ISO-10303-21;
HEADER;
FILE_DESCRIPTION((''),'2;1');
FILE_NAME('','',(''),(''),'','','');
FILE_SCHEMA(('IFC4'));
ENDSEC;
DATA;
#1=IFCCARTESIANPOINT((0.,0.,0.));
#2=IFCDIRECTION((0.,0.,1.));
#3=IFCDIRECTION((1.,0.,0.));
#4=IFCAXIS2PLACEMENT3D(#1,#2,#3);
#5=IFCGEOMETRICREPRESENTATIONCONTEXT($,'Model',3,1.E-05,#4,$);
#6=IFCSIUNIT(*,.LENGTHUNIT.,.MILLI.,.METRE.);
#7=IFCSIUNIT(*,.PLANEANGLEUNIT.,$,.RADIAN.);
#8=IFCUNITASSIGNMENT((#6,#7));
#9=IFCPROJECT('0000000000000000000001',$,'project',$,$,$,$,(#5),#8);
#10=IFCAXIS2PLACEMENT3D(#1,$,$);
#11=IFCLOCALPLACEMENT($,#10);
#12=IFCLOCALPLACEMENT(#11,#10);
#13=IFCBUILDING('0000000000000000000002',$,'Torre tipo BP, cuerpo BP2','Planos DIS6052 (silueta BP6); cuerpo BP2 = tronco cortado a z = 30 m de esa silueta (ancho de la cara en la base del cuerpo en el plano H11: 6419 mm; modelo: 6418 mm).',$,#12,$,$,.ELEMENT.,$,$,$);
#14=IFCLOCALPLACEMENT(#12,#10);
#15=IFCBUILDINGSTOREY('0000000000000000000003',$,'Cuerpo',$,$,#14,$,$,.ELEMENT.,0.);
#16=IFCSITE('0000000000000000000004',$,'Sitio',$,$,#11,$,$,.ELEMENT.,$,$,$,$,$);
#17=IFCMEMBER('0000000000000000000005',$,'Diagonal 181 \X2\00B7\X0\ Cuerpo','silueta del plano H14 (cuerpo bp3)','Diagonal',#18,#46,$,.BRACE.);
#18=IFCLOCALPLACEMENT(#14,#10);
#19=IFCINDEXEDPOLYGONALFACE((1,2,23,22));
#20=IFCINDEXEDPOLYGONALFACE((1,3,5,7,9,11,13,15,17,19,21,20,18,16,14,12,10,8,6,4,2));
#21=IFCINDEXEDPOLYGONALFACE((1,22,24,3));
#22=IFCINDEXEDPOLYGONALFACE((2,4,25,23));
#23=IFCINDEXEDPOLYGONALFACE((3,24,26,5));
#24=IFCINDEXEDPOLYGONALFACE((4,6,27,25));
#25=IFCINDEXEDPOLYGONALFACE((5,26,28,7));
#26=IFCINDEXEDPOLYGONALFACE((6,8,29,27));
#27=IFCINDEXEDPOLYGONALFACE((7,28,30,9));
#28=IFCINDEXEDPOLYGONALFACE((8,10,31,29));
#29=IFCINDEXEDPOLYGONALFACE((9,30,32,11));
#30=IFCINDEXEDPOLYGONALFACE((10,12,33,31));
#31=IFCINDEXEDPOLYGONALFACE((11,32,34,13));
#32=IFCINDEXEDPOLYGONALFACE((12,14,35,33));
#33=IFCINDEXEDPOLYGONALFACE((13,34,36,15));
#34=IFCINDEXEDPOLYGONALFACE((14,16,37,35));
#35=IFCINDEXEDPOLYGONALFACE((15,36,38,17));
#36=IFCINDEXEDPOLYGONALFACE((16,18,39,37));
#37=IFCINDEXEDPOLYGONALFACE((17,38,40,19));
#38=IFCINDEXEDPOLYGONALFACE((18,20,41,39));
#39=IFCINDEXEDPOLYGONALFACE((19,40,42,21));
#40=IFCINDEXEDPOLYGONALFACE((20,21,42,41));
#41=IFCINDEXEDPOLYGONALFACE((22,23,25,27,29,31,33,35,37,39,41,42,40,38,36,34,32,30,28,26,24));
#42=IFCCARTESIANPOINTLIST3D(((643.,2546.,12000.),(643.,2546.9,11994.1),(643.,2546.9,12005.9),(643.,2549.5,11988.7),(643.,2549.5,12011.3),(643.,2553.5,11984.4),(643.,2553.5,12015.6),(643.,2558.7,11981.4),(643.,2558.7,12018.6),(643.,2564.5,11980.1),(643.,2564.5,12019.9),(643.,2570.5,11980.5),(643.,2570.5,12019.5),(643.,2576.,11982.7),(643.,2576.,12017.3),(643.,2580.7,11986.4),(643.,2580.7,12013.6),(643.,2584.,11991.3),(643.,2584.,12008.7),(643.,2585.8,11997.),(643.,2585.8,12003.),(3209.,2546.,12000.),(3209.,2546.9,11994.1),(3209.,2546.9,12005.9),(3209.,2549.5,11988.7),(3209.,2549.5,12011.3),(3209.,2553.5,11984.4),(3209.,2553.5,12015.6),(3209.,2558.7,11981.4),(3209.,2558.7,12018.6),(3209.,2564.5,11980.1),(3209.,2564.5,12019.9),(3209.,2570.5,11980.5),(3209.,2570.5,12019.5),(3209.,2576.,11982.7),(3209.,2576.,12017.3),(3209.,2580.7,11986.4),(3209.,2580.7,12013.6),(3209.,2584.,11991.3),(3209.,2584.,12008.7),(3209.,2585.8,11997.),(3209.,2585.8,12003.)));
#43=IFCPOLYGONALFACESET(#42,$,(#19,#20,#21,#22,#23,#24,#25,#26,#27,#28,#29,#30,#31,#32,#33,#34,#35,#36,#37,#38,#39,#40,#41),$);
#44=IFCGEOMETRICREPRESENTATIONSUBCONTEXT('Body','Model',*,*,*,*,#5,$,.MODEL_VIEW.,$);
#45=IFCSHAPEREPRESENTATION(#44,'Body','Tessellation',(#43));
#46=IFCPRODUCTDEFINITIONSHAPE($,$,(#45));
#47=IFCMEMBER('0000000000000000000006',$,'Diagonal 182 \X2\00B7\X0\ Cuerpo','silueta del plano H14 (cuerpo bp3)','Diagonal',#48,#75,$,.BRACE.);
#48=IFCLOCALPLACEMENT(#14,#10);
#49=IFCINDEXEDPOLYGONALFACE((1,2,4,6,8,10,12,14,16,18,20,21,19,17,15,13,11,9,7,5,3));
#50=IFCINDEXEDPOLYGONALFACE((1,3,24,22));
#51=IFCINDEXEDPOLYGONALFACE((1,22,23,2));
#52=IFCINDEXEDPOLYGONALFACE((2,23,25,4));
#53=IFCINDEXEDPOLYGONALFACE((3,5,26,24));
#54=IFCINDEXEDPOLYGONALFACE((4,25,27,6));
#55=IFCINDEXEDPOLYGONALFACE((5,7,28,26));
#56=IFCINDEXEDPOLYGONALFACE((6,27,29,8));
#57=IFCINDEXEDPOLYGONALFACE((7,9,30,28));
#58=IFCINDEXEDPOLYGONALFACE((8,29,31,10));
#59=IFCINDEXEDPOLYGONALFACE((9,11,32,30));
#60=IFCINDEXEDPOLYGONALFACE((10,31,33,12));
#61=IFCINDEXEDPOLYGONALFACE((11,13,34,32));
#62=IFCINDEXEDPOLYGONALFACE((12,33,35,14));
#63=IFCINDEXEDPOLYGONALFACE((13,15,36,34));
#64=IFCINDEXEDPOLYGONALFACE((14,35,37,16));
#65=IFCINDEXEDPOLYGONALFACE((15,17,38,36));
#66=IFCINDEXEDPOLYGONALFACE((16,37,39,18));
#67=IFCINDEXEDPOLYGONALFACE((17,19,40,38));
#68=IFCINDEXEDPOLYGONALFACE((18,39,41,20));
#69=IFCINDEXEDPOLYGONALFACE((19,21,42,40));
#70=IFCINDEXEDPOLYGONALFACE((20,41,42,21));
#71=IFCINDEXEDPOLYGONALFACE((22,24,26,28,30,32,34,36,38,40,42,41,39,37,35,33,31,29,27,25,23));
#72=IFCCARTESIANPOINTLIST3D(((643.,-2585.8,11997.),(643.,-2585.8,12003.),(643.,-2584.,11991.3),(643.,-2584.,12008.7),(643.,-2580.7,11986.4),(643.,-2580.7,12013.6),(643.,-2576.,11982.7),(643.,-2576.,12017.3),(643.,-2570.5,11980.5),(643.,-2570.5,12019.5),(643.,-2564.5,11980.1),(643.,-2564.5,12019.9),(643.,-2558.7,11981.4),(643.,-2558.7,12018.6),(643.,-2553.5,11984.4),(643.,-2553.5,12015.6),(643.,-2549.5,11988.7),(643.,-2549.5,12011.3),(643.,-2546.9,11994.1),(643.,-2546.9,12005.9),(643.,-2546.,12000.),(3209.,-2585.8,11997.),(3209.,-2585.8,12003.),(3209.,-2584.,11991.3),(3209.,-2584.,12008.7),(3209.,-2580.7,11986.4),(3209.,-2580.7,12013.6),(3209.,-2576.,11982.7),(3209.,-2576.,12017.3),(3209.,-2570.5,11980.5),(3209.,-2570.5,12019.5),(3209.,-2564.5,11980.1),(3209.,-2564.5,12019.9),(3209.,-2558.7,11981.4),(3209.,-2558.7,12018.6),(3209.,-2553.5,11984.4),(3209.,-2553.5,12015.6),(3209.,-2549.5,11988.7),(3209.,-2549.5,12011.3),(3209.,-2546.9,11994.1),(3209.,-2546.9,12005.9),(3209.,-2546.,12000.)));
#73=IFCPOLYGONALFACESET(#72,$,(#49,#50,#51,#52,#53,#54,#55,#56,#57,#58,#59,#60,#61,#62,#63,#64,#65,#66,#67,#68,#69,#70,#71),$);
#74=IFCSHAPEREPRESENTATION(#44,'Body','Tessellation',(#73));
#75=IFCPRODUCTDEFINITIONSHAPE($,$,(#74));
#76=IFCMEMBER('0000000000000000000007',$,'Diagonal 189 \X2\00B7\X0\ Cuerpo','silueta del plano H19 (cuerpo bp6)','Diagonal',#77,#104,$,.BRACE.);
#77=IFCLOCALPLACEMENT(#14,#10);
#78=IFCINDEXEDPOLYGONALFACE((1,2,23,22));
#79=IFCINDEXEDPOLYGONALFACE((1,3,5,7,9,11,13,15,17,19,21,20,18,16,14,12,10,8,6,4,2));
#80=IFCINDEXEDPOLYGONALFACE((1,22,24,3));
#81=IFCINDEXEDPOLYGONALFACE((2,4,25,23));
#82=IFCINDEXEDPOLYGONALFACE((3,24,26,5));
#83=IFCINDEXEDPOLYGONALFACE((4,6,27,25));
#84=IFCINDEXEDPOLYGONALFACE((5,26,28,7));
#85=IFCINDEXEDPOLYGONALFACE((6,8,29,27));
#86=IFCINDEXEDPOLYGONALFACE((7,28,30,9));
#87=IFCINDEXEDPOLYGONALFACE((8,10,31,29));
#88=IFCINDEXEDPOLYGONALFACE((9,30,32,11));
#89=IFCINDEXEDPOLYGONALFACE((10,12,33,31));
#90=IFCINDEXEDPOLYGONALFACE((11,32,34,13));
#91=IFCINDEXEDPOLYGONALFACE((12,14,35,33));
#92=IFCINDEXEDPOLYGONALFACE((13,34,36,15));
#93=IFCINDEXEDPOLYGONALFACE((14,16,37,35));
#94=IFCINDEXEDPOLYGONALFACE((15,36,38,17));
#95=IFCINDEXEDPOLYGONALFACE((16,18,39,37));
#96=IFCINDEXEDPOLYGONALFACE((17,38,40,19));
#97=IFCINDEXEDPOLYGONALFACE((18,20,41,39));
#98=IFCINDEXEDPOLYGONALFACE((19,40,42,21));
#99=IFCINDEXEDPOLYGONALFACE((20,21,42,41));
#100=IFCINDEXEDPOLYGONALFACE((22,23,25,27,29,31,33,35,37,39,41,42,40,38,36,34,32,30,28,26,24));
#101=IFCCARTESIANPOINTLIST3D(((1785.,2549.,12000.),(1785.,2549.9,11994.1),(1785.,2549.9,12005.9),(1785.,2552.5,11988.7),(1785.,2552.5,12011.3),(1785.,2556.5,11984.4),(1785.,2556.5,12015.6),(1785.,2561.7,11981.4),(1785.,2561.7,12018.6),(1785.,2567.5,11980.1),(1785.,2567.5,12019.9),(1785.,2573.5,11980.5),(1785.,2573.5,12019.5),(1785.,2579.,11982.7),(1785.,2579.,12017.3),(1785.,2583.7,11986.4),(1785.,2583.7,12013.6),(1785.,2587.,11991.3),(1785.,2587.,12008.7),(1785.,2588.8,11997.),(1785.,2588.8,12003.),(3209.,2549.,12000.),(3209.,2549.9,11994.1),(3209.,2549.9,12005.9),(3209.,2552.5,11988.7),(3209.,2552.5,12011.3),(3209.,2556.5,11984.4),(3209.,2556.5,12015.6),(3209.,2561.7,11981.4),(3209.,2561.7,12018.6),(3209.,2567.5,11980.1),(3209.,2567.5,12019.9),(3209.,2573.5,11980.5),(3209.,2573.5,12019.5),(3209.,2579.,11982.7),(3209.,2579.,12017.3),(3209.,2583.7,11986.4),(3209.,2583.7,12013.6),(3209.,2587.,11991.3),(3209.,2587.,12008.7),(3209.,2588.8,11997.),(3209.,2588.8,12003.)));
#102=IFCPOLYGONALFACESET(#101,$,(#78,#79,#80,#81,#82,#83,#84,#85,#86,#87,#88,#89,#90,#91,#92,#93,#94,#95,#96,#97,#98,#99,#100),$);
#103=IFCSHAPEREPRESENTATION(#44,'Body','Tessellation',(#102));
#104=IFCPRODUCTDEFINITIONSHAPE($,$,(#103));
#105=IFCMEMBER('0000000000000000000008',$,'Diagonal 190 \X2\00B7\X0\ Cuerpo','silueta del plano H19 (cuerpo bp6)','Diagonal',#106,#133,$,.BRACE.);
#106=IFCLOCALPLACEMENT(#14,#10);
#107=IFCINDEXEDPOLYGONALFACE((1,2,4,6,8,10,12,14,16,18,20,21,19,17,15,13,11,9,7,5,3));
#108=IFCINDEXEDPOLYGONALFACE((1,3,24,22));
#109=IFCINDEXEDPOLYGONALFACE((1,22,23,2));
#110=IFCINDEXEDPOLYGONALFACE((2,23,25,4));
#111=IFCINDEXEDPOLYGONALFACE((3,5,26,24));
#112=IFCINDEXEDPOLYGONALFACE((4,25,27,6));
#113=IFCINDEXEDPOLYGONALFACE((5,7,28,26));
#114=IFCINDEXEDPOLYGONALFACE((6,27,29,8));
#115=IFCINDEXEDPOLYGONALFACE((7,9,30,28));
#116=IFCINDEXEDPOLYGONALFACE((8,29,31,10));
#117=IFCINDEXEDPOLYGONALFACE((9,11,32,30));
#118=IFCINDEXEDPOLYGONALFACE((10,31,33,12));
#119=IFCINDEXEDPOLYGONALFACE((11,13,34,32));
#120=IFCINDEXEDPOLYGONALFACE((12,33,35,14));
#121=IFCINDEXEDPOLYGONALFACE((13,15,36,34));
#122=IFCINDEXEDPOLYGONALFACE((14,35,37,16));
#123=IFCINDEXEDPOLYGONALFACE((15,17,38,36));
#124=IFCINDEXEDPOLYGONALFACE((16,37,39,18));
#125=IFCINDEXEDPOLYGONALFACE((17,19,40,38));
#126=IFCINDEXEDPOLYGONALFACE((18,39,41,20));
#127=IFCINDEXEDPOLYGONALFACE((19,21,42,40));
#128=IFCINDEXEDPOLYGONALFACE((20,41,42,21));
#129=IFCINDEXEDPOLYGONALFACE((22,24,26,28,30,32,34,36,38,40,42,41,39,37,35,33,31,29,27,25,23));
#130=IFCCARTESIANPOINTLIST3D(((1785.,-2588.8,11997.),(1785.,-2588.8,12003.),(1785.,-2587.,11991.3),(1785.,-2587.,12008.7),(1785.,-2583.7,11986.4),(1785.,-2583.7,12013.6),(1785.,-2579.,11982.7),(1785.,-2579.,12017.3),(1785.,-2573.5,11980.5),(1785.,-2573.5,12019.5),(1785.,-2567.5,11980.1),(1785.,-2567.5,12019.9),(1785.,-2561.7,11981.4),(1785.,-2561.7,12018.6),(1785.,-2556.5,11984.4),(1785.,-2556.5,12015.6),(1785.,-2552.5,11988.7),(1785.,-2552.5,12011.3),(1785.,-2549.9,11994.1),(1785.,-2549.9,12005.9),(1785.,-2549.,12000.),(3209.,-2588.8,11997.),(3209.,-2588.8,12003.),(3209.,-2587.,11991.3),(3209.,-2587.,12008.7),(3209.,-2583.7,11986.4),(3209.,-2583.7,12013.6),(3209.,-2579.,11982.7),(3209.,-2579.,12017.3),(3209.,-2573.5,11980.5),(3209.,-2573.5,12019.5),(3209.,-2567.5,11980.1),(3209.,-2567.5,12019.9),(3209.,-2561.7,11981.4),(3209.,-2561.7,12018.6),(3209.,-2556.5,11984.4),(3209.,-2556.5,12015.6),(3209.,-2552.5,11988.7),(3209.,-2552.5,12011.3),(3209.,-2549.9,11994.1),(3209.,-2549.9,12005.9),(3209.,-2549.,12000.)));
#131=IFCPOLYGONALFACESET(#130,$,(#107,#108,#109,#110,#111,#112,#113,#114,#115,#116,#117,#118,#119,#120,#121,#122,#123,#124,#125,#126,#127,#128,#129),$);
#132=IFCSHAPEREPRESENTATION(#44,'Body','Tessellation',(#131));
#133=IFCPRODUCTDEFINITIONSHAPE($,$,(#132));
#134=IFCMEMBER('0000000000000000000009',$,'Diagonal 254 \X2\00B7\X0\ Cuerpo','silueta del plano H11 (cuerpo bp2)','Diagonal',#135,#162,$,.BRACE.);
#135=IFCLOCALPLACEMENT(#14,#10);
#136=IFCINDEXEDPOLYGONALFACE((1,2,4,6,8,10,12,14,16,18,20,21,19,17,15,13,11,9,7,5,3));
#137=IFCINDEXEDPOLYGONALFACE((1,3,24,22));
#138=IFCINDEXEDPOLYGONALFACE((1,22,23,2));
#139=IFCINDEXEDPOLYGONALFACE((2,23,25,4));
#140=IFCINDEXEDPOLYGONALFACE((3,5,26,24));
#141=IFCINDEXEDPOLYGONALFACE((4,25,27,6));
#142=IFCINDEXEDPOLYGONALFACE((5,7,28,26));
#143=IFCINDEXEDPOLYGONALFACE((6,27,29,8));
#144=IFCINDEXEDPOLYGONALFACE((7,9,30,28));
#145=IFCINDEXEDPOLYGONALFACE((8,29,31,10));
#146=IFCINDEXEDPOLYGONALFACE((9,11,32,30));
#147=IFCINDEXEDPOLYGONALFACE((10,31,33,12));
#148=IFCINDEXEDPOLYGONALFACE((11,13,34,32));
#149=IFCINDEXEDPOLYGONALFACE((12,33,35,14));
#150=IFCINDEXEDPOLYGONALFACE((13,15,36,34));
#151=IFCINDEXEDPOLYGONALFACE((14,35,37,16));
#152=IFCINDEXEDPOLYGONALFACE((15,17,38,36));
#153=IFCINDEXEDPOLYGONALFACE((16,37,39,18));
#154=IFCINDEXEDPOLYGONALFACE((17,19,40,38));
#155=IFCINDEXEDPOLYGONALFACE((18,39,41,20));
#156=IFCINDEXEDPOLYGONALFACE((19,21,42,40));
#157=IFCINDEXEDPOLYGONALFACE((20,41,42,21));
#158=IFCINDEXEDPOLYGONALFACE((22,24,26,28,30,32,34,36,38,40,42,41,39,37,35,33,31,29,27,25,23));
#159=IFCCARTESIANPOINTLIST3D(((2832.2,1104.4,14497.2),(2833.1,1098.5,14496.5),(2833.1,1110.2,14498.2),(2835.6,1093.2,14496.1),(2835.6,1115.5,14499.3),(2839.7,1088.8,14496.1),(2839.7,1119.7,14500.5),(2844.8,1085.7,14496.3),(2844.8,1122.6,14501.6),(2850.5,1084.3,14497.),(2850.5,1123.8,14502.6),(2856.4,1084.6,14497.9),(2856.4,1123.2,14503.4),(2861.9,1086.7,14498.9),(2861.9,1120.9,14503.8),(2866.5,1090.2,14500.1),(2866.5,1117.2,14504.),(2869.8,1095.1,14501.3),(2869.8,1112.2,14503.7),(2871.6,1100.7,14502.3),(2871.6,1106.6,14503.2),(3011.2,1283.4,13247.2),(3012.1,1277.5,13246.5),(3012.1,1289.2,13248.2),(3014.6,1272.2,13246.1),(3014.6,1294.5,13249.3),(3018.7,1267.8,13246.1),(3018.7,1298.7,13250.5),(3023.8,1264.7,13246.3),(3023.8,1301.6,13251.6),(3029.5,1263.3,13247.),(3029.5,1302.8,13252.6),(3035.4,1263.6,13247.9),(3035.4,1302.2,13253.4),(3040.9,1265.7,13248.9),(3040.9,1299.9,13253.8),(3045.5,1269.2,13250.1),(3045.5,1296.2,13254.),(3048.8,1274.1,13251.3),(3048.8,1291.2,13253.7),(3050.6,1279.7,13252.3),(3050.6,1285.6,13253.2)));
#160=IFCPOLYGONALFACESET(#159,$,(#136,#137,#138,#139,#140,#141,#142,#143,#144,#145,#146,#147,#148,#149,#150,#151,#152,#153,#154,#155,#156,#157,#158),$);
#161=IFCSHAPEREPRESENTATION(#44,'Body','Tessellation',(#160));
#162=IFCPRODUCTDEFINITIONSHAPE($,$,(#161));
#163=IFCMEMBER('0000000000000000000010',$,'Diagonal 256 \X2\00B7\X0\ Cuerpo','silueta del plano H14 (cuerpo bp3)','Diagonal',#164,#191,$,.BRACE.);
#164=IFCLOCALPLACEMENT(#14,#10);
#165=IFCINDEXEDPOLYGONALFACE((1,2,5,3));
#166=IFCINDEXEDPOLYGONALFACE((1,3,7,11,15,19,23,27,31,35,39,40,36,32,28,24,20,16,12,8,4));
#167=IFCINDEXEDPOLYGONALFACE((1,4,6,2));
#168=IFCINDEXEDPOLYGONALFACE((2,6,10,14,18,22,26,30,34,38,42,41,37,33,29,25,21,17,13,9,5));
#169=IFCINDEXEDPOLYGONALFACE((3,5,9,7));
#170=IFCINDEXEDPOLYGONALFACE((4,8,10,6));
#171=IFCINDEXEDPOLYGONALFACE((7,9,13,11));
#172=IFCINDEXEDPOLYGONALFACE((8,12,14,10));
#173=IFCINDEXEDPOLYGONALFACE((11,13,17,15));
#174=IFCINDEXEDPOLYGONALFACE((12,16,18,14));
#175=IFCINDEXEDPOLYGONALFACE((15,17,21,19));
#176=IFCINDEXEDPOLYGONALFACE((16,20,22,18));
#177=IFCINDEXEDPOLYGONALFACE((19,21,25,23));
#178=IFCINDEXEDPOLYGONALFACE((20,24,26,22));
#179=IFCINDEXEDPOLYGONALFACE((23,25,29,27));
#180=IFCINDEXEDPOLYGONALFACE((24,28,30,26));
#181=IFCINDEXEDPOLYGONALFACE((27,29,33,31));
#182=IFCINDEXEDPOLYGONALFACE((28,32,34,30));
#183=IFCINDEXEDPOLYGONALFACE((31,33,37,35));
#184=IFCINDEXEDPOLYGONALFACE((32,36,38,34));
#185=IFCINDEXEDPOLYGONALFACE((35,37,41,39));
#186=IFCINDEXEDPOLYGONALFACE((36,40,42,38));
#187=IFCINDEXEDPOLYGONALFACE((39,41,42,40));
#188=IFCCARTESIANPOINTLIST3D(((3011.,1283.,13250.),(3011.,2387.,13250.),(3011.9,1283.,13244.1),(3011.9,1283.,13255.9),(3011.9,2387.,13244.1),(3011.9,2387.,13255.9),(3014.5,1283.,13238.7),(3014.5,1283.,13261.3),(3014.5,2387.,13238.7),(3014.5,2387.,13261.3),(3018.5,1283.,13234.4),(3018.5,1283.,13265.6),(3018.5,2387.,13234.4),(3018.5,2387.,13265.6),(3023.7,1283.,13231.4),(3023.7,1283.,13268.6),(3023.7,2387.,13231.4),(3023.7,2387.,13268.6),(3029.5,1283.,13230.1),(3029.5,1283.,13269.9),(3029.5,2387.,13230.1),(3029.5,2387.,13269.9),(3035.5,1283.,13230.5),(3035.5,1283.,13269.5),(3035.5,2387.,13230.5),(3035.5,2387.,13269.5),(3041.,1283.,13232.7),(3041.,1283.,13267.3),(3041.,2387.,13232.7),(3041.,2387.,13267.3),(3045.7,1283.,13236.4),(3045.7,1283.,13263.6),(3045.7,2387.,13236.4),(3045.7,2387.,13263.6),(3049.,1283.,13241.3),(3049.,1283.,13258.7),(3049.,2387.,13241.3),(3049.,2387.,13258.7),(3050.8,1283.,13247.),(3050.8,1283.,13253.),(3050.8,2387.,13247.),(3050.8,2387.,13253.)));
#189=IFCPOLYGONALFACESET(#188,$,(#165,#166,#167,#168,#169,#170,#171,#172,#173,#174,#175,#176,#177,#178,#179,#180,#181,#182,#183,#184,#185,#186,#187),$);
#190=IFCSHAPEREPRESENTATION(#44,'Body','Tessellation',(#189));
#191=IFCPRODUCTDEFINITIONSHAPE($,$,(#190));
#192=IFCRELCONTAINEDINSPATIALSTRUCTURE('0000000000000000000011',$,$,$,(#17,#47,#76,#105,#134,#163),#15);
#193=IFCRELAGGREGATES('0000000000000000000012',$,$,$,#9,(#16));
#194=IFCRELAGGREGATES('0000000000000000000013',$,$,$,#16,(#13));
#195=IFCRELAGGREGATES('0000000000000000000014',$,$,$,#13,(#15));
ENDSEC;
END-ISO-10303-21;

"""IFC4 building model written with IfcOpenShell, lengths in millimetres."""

from ifc_helpers import new_model, si_unit, frame, origin, origin_with_axes, place, context, subcontext, project, spatial, circle, extrude, element, save


model = new_model("IFC4")

# Units and contexts
model_context = context("Model", 3, precision=1e-05, world=origin_with_axes())
body_context = subcontext(model_context, "Body", "Model", "MODEL_VIEW")
ifc_project = project(units=[si_unit("LENGTHUNIT", "METRE", prefix="MILLI"), si_unit("PLANEANGLEUNIT", "RADIAN")], contexts=[model_context])

# Site, building, storey
site_placement = place(None, origin())
site = spatial("IfcSite", under=ifc_project, at=site_placement, Name="Sitio", CompositionType="ELEMENT")
building_placement = place(site_placement, origin())
building = spatial("IfcBuilding", under=site, at=building_placement, Name="Torre tipo BP, cuerpo BP2", Description="Planos DIS6052 (silueta BP6); cuerpo BP2 = tronco cortado a z = 30 m de esa silueta (ancho de la cara en la base del cuerpo en el plano H11: 6419 mm; modelo: 6418 mm).", CompositionType="ELEMENT")
storey_placement = place(building_placement, origin())
storey = spatial("IfcBuildingStorey", under=building, at=storey_placement, Name="Cuerpo", CompositionType="ELEMENT", Elevation=0.0)

# Members
for number, where, z_axis, x_axis, name in (
    (1, (3209.0, 2566.0, 12000.0), (-1.0, 0.0, 0.0), (0.0, -1.0, 0.0), "Diagonal 181 · Cuerpo"),
    (2, (3209.0, -2566.0, 12000.0), (-1.0, 0.0, 0.0), (0.0, 1.0, 0.0), "Diagonal 182 · Cuerpo"),
):
    element("IfcMember", number, at=place(storey_placement, frame(where, z_axis=z_axis, x_axis=x_axis)), inside=storey, Name=name, Description="silueta del plano H14 (cuerpo bp3)", ObjectType="Diagonal", PredefinedType="BRACE", context=body_context, shape_type="SweptSolid", body=[
        extrude(circle(Radius=20.0), None, (0.0, 0.0, 1.0), 2566.0),
    ])
for number, where, z_axis, x_axis, name in (
    (3, (3209.0, 2569.0, 12000.0), (-1.0, 0.0, 0.0), (0.0, -1.0, 0.0), "Diagonal 189 · Cuerpo"),
    (4, (3209.0, -2569.0, 12000.0), (-1.0, 0.0, 0.0), (0.0, 1.0, 0.0), "Diagonal 190 · Cuerpo"),
):
    element("IfcMember", number, at=place(storey_placement, frame(where, z_axis=z_axis, x_axis=x_axis)), inside=storey, Name=name, Description="silueta del plano H19 (cuerpo bp6)", ObjectType="Diagonal", PredefinedType="BRACE", context=body_context, shape_type="SweptSolid", body=[
        extrude(circle(Radius=20.0), None, (0.0, 0.0, 1.0), 1424.0),
    ])
member_1_placement = place(storey_placement, frame((2852.0, 1104.0, 14500.0), z_axis=(0.140351, 0.140351, -0.980104), x_axis=(-0.990102, 0.019895, -0.138934)))
element("IfcMember", 5, at=member_1_placement, inside=storey, Name="Diagonal 254 · Cuerpo", Description="silueta del plano H11 (cuerpo bp2)", ObjectType="Diagonal", PredefinedType="BRACE", context=body_context, shape_type="SweptSolid", body=[
    extrude(circle(Radius=20.0), None, (0.0, 0.0, 1.0), 1275.4),
])
member_2_placement = place(storey_placement, frame((3031.0, 1283.0, 13250.0), z_axis=(0.0, 1.0, 0.0), x_axis=(-1.0, 0.0, 0.0)))
element("IfcMember", 6, at=member_2_placement, inside=storey, Name="Diagonal 256 · Cuerpo", Description="silueta del plano H14 (cuerpo bp3)", ObjectType="Diagonal", PredefinedType="BRACE", context=body_context, shape_type="SweptSolid", body=[
    extrude(circle(Radius=20.0), None, (0.0, 0.0, 1.0), 1104.0),
])

save(model, "model.ifc")
